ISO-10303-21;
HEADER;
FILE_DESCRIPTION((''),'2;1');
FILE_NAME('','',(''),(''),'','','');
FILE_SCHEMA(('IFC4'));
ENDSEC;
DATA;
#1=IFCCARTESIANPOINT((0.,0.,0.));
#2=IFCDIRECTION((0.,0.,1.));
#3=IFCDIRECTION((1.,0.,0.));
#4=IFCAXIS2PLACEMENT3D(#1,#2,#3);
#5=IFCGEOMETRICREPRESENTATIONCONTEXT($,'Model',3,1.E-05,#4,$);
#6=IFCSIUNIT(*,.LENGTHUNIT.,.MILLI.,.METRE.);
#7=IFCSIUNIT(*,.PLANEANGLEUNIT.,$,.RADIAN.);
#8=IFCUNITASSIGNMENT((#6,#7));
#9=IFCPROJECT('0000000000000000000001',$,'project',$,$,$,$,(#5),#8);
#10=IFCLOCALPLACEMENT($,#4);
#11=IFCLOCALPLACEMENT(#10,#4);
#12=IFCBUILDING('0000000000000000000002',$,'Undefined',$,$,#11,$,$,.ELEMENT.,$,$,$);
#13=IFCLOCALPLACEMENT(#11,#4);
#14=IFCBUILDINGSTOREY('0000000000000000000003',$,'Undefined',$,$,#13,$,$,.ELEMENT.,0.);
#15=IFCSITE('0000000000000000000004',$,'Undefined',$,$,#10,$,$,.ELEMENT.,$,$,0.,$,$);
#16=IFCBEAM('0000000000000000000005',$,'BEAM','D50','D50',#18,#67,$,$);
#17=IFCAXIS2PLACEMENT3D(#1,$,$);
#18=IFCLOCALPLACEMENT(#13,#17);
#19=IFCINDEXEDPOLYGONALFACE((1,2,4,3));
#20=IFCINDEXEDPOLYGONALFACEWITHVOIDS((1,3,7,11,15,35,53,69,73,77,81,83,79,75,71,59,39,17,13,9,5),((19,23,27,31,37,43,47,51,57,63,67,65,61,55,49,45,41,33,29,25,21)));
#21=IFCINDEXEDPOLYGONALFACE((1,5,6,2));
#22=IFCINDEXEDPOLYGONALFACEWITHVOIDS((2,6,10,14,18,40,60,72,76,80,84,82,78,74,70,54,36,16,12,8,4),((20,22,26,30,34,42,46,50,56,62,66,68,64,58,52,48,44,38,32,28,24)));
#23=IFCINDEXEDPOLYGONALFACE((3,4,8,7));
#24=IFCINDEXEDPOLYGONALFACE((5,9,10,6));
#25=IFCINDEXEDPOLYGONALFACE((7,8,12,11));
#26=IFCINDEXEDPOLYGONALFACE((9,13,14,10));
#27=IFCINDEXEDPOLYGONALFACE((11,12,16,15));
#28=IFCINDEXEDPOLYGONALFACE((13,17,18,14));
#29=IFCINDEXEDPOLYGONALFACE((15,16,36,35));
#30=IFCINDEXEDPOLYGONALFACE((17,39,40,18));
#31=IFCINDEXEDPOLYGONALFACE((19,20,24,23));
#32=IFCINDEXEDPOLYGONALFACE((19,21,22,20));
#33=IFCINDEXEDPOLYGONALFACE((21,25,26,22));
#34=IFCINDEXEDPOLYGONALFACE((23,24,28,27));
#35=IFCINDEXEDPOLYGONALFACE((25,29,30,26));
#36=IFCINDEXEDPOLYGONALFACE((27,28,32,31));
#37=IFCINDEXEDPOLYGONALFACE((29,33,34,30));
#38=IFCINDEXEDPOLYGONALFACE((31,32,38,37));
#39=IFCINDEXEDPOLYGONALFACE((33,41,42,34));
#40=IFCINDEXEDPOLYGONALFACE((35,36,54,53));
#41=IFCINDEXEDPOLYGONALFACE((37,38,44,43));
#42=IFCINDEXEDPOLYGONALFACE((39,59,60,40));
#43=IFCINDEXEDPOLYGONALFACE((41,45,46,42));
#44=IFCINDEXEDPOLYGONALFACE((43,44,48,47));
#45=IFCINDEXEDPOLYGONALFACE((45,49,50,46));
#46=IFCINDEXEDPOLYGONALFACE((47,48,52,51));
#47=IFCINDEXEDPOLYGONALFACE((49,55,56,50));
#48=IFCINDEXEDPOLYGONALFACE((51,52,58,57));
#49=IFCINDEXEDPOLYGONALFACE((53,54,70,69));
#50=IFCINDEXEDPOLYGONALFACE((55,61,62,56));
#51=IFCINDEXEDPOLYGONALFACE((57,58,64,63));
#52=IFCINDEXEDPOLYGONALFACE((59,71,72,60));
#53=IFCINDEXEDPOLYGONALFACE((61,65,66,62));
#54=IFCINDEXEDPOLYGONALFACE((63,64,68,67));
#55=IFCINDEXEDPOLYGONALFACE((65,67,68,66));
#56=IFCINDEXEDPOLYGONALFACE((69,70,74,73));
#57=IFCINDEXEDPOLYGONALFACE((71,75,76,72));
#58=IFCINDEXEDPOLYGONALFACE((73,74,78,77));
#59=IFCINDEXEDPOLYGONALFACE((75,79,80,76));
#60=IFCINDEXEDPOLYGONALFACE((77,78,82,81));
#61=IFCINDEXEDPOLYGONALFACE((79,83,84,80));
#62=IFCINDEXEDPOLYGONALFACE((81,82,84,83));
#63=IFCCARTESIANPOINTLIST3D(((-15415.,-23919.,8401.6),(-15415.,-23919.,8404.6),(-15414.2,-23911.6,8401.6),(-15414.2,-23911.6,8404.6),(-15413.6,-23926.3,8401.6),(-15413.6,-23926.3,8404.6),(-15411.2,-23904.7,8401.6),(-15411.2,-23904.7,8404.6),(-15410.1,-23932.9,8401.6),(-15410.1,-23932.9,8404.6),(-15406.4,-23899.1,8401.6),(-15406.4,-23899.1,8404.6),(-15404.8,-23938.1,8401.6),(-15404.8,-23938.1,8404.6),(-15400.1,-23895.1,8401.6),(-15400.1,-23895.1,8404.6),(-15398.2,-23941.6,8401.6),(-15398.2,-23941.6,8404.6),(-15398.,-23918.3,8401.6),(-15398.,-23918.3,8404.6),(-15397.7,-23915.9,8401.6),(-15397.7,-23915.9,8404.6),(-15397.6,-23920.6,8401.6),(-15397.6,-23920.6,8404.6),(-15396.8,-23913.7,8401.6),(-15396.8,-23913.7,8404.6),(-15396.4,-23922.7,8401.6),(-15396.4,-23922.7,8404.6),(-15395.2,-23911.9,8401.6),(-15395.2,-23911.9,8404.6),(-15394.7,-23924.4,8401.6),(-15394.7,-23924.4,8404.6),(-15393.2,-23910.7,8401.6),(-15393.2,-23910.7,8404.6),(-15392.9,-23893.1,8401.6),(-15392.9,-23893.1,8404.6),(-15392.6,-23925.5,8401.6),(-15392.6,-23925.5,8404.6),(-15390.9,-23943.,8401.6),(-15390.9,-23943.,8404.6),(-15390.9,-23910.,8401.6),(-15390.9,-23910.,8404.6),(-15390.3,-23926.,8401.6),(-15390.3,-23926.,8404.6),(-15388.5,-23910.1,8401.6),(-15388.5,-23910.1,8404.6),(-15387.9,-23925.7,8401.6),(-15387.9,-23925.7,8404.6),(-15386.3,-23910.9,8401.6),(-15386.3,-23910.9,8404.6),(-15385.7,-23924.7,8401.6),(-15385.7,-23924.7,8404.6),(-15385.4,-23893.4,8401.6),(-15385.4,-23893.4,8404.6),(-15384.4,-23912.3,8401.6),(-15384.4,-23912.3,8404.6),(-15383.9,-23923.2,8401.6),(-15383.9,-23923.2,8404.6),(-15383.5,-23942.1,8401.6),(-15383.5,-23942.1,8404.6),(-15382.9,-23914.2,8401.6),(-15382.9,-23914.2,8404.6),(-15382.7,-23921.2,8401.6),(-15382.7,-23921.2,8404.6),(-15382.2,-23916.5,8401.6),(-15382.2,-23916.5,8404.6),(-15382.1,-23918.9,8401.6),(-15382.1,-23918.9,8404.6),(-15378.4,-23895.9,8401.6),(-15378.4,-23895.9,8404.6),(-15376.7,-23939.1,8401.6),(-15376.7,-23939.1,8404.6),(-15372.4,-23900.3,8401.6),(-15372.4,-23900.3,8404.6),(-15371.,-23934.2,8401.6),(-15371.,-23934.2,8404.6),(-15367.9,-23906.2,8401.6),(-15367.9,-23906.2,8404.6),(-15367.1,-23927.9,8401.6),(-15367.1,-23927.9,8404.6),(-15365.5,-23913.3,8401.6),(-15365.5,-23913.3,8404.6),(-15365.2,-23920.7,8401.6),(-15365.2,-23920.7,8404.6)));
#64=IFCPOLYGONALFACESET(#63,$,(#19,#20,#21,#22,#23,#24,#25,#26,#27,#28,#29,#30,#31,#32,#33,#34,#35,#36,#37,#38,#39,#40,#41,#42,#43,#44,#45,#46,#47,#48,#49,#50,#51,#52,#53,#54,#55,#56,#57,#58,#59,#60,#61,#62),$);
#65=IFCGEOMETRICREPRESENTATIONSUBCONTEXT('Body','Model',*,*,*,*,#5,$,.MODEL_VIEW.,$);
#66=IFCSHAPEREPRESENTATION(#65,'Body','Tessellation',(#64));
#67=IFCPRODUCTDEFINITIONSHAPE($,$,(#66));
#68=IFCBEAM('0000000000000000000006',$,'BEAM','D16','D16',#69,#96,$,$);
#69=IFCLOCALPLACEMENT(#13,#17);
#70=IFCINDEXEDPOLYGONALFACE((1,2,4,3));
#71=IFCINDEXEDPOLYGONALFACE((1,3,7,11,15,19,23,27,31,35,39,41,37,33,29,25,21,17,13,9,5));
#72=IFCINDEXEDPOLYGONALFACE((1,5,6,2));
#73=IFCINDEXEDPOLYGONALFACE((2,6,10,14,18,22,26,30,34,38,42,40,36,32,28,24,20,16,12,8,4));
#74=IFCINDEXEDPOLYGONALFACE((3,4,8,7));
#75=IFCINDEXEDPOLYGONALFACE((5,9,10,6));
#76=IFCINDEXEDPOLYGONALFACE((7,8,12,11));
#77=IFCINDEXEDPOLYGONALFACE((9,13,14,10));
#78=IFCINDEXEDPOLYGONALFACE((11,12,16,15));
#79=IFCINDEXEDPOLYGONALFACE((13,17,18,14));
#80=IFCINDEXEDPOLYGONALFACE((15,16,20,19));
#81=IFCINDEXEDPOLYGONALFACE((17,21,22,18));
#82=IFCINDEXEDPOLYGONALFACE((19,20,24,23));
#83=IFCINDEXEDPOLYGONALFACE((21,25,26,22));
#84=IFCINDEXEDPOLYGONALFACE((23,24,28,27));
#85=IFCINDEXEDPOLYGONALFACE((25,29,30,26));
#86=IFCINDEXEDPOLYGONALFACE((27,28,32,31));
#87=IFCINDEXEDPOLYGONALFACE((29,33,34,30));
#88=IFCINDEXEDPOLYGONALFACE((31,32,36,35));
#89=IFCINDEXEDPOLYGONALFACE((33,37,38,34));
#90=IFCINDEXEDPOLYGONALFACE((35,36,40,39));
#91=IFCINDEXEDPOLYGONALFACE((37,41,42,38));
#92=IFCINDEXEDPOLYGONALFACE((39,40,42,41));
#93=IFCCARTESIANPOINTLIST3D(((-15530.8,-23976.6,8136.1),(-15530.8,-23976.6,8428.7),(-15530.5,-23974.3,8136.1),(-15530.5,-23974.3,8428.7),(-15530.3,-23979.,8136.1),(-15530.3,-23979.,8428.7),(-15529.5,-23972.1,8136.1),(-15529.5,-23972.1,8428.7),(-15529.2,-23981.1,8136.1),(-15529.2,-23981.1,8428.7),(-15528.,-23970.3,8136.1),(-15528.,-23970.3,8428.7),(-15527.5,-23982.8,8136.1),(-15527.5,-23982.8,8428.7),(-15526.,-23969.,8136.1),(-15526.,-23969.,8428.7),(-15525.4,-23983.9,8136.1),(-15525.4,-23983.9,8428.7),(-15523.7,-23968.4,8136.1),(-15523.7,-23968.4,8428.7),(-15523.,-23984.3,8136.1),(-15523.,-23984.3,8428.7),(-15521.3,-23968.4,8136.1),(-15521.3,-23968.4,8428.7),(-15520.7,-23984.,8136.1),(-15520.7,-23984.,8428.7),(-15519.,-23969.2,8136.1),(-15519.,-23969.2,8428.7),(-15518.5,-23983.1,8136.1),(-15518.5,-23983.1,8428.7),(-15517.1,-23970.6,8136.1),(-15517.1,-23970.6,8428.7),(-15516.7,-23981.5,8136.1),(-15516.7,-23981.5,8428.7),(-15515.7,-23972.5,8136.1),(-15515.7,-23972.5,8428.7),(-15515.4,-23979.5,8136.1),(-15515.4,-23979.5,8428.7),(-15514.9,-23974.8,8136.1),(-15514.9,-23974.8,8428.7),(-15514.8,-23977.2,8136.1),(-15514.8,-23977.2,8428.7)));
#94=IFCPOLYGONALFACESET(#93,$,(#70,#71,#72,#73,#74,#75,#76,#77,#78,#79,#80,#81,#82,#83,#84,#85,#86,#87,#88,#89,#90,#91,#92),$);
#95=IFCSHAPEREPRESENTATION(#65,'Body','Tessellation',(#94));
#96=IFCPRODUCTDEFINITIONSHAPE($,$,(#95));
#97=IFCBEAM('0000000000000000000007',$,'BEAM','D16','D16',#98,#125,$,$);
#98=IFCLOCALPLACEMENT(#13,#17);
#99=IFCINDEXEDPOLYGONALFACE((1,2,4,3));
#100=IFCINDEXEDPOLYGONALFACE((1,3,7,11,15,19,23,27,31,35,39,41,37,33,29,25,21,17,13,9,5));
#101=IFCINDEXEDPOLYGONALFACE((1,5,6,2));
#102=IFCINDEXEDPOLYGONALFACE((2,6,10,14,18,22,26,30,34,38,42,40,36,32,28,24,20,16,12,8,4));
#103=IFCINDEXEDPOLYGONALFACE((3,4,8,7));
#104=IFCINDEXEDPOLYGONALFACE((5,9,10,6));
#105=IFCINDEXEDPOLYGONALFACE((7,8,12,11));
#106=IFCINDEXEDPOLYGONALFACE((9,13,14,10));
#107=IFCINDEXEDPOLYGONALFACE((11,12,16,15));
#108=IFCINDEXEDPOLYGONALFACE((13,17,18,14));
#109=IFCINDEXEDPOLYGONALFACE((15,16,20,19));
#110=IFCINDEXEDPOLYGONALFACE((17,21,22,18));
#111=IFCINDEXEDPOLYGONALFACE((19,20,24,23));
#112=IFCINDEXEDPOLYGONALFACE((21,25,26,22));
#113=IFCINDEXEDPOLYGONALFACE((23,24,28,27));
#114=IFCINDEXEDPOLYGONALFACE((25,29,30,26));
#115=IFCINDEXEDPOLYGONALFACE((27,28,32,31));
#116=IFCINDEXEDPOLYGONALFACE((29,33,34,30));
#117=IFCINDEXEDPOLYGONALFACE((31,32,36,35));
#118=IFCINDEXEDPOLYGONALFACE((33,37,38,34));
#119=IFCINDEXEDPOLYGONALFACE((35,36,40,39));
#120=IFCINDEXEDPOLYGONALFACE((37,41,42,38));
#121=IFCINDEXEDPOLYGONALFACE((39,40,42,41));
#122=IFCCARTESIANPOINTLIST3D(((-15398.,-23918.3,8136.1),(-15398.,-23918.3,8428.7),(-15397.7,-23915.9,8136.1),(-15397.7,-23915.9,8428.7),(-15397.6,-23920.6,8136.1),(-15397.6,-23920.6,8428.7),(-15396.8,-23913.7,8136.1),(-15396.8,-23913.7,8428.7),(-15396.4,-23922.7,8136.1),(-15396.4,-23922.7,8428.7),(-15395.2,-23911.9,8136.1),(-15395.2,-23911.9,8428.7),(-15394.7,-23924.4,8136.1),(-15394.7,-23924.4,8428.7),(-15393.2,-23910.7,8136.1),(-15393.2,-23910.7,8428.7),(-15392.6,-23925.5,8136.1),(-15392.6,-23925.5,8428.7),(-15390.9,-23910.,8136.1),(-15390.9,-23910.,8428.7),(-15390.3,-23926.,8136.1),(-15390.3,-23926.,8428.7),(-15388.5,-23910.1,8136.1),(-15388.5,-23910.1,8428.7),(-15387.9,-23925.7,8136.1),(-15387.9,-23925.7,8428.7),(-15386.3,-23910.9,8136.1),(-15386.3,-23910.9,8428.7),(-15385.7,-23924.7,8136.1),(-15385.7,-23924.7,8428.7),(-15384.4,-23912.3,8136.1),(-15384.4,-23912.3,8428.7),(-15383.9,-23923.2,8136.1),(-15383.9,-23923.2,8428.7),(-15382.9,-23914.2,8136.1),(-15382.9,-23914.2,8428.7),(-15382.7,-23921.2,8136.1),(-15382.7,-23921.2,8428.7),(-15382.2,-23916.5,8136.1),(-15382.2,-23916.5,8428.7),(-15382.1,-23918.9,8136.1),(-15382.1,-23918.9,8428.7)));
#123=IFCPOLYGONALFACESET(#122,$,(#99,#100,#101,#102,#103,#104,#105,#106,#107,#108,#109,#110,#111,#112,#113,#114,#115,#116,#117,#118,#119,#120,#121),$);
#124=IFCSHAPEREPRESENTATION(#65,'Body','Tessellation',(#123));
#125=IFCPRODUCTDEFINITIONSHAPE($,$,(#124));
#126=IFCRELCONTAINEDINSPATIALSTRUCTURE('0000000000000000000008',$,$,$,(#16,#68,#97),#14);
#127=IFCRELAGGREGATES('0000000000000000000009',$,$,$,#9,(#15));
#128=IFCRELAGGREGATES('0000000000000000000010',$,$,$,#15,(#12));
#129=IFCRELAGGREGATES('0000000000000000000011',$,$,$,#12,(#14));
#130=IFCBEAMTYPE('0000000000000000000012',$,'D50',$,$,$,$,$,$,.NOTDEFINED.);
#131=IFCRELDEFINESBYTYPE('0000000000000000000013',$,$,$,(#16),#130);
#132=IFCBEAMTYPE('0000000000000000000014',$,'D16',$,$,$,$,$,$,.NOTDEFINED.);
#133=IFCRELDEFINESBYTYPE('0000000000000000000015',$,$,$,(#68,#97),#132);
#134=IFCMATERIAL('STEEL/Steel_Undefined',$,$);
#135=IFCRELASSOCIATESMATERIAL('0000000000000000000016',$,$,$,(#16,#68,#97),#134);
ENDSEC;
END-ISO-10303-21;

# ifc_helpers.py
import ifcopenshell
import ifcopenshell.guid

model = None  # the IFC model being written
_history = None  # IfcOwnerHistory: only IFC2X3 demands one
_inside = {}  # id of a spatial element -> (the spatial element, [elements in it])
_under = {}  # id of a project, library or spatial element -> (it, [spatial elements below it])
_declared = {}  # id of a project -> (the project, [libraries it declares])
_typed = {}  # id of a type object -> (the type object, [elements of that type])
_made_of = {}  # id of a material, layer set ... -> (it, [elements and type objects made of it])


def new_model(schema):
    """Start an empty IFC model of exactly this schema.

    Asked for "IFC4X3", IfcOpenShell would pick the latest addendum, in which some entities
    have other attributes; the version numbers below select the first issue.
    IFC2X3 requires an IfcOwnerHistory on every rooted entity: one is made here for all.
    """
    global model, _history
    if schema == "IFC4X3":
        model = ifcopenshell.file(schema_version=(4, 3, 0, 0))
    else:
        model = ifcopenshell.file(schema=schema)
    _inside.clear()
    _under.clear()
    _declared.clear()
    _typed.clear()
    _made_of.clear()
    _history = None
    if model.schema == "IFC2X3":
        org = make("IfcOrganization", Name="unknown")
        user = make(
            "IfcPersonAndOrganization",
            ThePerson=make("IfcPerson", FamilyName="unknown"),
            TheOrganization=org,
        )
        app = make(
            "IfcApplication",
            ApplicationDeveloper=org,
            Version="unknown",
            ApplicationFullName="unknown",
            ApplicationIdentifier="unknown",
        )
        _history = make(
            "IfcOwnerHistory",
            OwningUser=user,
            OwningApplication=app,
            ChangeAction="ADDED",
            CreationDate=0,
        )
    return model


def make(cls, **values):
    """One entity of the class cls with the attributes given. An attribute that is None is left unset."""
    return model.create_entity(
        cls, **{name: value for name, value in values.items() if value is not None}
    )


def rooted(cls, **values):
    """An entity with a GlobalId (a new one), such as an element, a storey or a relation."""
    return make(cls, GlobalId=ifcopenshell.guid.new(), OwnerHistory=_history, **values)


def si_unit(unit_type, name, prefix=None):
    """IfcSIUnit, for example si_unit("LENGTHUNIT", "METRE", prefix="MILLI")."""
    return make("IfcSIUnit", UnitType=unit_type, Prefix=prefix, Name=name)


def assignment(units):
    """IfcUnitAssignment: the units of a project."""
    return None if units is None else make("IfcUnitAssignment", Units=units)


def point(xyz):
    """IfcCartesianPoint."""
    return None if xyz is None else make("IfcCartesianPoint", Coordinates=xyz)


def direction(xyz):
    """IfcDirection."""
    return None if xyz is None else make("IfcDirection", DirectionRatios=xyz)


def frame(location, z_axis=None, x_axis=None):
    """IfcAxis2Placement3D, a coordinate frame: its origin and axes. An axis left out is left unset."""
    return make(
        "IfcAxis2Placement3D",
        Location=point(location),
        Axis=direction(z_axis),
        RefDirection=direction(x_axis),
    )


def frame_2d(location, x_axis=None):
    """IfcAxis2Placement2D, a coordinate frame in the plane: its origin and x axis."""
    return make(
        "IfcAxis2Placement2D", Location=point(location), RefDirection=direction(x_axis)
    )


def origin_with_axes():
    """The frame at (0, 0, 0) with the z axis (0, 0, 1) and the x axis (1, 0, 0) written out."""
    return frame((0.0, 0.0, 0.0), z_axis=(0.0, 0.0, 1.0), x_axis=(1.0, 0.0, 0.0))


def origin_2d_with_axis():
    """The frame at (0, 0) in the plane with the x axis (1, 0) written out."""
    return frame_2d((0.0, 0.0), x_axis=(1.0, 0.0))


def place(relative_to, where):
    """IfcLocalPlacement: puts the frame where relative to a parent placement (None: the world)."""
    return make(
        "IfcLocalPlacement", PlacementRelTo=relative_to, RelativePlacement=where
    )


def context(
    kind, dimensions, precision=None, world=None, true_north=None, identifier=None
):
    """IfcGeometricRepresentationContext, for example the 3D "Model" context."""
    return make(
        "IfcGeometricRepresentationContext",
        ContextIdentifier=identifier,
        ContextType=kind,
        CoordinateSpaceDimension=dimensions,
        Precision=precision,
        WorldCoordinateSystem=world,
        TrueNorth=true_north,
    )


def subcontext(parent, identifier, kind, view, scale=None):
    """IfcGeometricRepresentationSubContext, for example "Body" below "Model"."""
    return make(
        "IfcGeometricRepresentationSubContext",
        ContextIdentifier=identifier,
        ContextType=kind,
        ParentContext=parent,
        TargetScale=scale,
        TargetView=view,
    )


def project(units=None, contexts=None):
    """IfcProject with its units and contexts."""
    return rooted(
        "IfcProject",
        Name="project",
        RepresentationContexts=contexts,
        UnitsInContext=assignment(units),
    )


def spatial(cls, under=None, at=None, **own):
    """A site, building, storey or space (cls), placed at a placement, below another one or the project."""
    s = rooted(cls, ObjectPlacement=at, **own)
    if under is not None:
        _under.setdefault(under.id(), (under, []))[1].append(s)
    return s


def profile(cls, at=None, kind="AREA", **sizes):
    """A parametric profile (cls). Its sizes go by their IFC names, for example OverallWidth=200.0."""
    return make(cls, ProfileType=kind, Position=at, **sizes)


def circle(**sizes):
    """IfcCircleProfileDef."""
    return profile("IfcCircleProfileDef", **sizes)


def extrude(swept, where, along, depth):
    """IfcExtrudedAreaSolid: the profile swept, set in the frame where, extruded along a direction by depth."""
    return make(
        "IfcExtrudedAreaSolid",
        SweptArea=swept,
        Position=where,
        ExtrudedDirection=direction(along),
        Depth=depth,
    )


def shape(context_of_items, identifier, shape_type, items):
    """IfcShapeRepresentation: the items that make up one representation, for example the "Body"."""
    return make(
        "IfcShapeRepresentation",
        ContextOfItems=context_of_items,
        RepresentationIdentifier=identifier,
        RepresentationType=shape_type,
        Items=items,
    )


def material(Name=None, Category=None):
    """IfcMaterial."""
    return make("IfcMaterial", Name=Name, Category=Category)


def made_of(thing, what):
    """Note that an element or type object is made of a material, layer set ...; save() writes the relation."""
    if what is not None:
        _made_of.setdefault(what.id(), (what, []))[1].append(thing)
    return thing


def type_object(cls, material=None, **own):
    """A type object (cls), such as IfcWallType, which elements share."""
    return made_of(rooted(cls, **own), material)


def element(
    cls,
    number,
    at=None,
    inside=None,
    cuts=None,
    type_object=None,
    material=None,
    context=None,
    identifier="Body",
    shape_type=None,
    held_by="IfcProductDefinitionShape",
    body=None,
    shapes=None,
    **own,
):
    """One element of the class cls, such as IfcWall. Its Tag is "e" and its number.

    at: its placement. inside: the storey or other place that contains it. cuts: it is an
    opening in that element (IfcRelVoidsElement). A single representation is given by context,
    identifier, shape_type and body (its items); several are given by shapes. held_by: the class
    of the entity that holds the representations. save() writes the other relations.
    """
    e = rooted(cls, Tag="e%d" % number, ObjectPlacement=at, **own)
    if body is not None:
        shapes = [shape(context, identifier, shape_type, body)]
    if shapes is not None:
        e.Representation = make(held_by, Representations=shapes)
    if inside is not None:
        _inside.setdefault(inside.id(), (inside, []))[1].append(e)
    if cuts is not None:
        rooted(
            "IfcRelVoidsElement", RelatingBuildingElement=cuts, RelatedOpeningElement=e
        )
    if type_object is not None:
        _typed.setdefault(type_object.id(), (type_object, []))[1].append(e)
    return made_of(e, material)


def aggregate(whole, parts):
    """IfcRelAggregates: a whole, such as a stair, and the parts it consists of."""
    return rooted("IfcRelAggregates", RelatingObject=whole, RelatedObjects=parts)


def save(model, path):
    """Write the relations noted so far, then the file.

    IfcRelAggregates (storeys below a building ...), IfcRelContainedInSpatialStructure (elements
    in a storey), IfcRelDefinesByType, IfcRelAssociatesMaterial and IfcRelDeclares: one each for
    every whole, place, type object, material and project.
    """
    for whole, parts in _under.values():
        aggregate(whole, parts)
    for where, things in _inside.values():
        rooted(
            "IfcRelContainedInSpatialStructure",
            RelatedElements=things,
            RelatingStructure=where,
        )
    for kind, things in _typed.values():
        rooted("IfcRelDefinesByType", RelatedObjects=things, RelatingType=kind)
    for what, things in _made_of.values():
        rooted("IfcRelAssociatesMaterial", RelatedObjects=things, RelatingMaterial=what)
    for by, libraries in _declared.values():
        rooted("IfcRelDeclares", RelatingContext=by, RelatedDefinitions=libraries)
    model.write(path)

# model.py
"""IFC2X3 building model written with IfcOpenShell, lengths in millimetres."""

from ifc_helpers import new_model, si_unit, frame, origin_with_axes, origin_2d_with_axis, place, context, subcontext, project, spatial, circle, extrude, material, type_object, element, save


model = new_model("IFC2X3")

# Units and contexts
model_context = context("Model", 3, precision=1e-05, world=origin_with_axes())
body_context = subcontext(model_context, "Body", "Model", "MODEL_VIEW")
ifc_project = project(units=[si_unit("LENGTHUNIT", "METRE", prefix="MILLI"), si_unit("PLANEANGLEUNIT", "RADIAN")], contexts=[model_context])

# Site, building, storey
site_placement = place(None, origin_with_axes())
site = spatial("IfcSite", under=ifc_project, at=site_placement, Name="Undefined", CompositionType="ELEMENT", RefElevation=0.0)
building_placement = place(site_placement, origin_with_axes())
building = spatial("IfcBuilding", under=site, at=building_placement, Name="Undefined", CompositionType="ELEMENT")
storey_placement = place(building_placement, origin_with_axes())
storey = spatial("IfcBuildingStorey", under=building, at=storey_placement, Name="Undefined", CompositionType="ELEMENT", Elevation=0.0)

# Shared definitions
ifc_material_1 = material(Name="STEEL/Steel_Undefined")

# Beam, opening
beam_type_1 = type_object("IfcBeamType", Name="D50", PredefinedType="NOTDEFINED")
beam_1_placement = place(storey_placement, frame((-15390.0, -23918.0, 8404.6), z_axis=(-0.915552, -0.4022, 0.0), x_axis=(0.0, 0.0, -1.0)))
beam_1 = element("IfcBeam", 1, at=beam_1_placement, inside=storey, type_object=beam_type_1, material=ifc_material_1, Name="BEAM", Description="D50", ObjectType="D50", context=body_context, shape_type="SweptSolid", body=[
    extrude(circle(Radius=25.0, at=origin_2d_with_axis()), frame((3.0, 0.0, 0.0), z_axis=(-1.0, 0.0, 0.0), x_axis=(0.0, -1.0, 0.0)), (0.0, 0.0, 1.0), 3.0),
])
opening_1_placement = place(storey_placement, frame((-15390.0, -23918.0, 8404.6), z_axis=(-0.915552, -0.4022, 0.0), x_axis=(0.0, 0.0, -1.0)))
element("IfcOpeningElement", 2, at=opening_1_placement, cuts=beam_1, ObjectType="Recess", context=body_context, shape_type="SweptSolid", body=[
    extrude(circle(Radius=8.0, at=origin_2d_with_axis()), frame((268.5, 0.0, 0.0), z_axis=(-1.0, 0.0, 0.0), x_axis=(0.0, -1.0, 0.0)), (0.0, 0.0, 1.0), 292.6),
])

# Beams
beam_type_2 = type_object("IfcBeamType", Name="D16", PredefinedType="NOTDEFINED")
for number, where, z_axis, x_axis, name in (
    (3, (-15522.8, -23976.3, 8428.7), (-0.915552, -0.4022, 0.0), (0.0, 0.0, -1.0), "BEAM"),
    (4, (-15390.0, -23918.0, 8428.7), (-0.915552, -0.4022, 0.0), (0.0, 0.0, -1.0), "BEAM"),
):
    element("IfcBeam", number, at=place(storey_placement, frame(where, z_axis=z_axis, x_axis=x_axis)), inside=storey, type_object=beam_type_2, material=ifc_material_1, Name=name, Description="D16", ObjectType="D16", context=body_context, shape_type="SweptSolid", body=[
        extrude(circle(Radius=8.0, at=origin_2d_with_axis()), frame((292.6, 0.0, 0.0), z_axis=(-1.0, 0.0, 0.0), x_axis=(0.0, -1.0, 0.0)), (0.0, 0.0, 1.0), 292.6),
    ])

save(model, "model.ifc")
